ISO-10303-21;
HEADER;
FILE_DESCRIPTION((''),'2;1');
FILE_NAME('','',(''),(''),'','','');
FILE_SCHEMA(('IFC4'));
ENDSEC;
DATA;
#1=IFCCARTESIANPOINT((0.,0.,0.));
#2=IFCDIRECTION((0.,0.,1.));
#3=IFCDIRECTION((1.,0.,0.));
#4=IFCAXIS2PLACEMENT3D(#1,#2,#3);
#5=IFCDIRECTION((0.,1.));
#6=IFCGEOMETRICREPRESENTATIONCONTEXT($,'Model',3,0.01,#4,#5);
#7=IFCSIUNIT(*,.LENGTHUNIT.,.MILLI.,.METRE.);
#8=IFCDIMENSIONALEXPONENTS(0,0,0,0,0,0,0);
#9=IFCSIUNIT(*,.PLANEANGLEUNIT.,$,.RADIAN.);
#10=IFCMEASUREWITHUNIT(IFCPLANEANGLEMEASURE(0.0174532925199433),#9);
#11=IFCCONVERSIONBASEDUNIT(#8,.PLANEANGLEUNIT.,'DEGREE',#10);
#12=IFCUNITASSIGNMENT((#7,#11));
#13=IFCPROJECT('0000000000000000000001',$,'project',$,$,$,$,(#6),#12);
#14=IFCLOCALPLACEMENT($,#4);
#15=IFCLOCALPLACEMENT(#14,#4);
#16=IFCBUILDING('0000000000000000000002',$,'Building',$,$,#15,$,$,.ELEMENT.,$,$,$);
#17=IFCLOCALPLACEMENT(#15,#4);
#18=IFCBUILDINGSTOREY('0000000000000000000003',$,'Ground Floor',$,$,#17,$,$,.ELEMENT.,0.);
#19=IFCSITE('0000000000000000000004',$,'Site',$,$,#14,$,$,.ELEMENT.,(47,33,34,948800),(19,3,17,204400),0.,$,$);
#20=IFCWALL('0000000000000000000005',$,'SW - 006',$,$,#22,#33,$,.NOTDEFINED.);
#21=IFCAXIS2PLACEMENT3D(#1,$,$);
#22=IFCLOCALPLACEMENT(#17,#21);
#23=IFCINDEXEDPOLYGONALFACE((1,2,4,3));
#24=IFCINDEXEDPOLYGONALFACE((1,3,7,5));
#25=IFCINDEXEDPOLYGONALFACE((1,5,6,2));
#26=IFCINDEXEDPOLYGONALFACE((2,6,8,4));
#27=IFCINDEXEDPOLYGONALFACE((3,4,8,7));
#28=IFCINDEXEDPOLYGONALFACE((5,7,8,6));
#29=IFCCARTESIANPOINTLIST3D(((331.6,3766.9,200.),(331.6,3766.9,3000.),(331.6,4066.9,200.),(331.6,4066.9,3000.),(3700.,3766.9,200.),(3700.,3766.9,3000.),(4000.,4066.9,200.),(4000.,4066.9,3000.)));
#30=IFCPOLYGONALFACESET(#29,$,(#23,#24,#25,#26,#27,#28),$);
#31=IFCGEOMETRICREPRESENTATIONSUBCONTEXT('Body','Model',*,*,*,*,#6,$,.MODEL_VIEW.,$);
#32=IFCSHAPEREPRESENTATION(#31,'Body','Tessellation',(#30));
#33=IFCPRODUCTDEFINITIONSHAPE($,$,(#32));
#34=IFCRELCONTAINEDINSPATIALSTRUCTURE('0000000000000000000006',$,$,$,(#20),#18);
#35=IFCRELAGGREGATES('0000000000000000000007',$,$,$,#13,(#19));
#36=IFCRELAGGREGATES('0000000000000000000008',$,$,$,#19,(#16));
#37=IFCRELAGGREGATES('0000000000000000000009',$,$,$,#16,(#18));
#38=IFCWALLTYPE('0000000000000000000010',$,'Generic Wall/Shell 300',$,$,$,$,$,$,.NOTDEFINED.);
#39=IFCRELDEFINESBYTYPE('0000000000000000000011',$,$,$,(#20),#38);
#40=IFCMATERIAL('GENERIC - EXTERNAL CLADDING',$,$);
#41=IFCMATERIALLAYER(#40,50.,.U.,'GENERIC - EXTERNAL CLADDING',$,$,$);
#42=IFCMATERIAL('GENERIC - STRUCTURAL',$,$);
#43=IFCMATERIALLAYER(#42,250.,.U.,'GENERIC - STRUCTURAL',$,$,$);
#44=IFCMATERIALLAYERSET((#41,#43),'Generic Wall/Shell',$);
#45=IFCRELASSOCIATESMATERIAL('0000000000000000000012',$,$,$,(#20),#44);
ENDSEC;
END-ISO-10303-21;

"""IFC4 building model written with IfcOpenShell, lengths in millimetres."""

from ifc_helpers import new_model, entity, si_unit, converted_unit, direction, frame, origin_with_axes, place, context, subcontext, project, spatial, line, indexed_curve, outline, extrude, material, layer, layer_set, layer_usage, type_object, element, save


model = new_model("IFC4")

# Units and contexts
model_context = context("Model", 3, precision=0.01, world=origin_with_axes(), true_north=direction((0.0, 1.0)))
body_context = subcontext(model_context, "Body", "Model", "MODEL_VIEW")
ifc_project = project(units=[si_unit("LENGTHUNIT", "METRE", prefix="MILLI"), converted_unit("PLANEANGLEUNIT", "DEGREE", entity("IfcPlaneAngleMeasure", 0.0174532925199433), si_unit("PLANEANGLEUNIT", "RADIAN"), dimensions=[0, 0, 0, 0, 0, 0, 0])], contexts=[model_context])

# Site, building, storey
site_placement = place(None, origin_with_axes())
site = spatial("IfcSite", under=ifc_project, at=site_placement, Name="Site", CompositionType="ELEMENT", RefLatitude=(47, 33, 34, 948800), RefLongitude=(19, 3, 17, 204400), RefElevation=0.0)
building_placement = place(site_placement, origin_with_axes())
building = spatial("IfcBuilding", under=site, at=building_placement, Name="Building", CompositionType="ELEMENT")
storey_placement = place(building_placement, origin_with_axes())
storey = spatial("IfcBuildingStorey", under=building, at=storey_placement, Name="Ground Floor", CompositionType="ELEMENT", Elevation=0.0)

# Wall
ifc_material_1 = material(Name="GENERIC - EXTERNAL CLADDING")
ifc_layer_1 = layer(ifc_material_1, 50.0, ventilated="UNKNOWN", Name="GENERIC - EXTERNAL CLADDING")
ifc_material_2 = material(Name="GENERIC - STRUCTURAL")
ifc_layer_2 = layer(ifc_material_2, 250.0, ventilated="UNKNOWN", Name="GENERIC - STRUCTURAL")
ifc_layer_set = layer_set([ifc_layer_1, ifc_layer_2], Name="Generic Wall/Shell")
ifc_layer_usage = layer_usage(ifc_layer_set, "AXIS2", "NEGATIVE", 300.0)
wall_type = type_object("IfcWallType", Name="Generic Wall/Shell 300", PredefinedType="NOTDEFINED")
wall_placement = place(storey_placement, frame((4000.0, 4066.9, 200.0), z_axis=(0.0, 0.0, 1.0), x_axis=(-1.0, 0.0, 0.0)))
element("IfcWall", 1, at=wall_placement, inside=storey, type_object=wall_type, material=ifc_layer_usage, Name="SW - 006", PredefinedType="NOTDEFINED", context=body_context, shape_type="SweptSolid", body=[
    extrude(outline(indexed_curve([(0.0, 0.0), (3668.4, 0.0), (3668.4, 300.0), (300.0, 300.0)], segments=[line(1, 2, 3, 4, 1)])), origin_with_axes(), (0.0, 0.0, 1.0), 2800.0),
])

save(model, "model.ifc")
